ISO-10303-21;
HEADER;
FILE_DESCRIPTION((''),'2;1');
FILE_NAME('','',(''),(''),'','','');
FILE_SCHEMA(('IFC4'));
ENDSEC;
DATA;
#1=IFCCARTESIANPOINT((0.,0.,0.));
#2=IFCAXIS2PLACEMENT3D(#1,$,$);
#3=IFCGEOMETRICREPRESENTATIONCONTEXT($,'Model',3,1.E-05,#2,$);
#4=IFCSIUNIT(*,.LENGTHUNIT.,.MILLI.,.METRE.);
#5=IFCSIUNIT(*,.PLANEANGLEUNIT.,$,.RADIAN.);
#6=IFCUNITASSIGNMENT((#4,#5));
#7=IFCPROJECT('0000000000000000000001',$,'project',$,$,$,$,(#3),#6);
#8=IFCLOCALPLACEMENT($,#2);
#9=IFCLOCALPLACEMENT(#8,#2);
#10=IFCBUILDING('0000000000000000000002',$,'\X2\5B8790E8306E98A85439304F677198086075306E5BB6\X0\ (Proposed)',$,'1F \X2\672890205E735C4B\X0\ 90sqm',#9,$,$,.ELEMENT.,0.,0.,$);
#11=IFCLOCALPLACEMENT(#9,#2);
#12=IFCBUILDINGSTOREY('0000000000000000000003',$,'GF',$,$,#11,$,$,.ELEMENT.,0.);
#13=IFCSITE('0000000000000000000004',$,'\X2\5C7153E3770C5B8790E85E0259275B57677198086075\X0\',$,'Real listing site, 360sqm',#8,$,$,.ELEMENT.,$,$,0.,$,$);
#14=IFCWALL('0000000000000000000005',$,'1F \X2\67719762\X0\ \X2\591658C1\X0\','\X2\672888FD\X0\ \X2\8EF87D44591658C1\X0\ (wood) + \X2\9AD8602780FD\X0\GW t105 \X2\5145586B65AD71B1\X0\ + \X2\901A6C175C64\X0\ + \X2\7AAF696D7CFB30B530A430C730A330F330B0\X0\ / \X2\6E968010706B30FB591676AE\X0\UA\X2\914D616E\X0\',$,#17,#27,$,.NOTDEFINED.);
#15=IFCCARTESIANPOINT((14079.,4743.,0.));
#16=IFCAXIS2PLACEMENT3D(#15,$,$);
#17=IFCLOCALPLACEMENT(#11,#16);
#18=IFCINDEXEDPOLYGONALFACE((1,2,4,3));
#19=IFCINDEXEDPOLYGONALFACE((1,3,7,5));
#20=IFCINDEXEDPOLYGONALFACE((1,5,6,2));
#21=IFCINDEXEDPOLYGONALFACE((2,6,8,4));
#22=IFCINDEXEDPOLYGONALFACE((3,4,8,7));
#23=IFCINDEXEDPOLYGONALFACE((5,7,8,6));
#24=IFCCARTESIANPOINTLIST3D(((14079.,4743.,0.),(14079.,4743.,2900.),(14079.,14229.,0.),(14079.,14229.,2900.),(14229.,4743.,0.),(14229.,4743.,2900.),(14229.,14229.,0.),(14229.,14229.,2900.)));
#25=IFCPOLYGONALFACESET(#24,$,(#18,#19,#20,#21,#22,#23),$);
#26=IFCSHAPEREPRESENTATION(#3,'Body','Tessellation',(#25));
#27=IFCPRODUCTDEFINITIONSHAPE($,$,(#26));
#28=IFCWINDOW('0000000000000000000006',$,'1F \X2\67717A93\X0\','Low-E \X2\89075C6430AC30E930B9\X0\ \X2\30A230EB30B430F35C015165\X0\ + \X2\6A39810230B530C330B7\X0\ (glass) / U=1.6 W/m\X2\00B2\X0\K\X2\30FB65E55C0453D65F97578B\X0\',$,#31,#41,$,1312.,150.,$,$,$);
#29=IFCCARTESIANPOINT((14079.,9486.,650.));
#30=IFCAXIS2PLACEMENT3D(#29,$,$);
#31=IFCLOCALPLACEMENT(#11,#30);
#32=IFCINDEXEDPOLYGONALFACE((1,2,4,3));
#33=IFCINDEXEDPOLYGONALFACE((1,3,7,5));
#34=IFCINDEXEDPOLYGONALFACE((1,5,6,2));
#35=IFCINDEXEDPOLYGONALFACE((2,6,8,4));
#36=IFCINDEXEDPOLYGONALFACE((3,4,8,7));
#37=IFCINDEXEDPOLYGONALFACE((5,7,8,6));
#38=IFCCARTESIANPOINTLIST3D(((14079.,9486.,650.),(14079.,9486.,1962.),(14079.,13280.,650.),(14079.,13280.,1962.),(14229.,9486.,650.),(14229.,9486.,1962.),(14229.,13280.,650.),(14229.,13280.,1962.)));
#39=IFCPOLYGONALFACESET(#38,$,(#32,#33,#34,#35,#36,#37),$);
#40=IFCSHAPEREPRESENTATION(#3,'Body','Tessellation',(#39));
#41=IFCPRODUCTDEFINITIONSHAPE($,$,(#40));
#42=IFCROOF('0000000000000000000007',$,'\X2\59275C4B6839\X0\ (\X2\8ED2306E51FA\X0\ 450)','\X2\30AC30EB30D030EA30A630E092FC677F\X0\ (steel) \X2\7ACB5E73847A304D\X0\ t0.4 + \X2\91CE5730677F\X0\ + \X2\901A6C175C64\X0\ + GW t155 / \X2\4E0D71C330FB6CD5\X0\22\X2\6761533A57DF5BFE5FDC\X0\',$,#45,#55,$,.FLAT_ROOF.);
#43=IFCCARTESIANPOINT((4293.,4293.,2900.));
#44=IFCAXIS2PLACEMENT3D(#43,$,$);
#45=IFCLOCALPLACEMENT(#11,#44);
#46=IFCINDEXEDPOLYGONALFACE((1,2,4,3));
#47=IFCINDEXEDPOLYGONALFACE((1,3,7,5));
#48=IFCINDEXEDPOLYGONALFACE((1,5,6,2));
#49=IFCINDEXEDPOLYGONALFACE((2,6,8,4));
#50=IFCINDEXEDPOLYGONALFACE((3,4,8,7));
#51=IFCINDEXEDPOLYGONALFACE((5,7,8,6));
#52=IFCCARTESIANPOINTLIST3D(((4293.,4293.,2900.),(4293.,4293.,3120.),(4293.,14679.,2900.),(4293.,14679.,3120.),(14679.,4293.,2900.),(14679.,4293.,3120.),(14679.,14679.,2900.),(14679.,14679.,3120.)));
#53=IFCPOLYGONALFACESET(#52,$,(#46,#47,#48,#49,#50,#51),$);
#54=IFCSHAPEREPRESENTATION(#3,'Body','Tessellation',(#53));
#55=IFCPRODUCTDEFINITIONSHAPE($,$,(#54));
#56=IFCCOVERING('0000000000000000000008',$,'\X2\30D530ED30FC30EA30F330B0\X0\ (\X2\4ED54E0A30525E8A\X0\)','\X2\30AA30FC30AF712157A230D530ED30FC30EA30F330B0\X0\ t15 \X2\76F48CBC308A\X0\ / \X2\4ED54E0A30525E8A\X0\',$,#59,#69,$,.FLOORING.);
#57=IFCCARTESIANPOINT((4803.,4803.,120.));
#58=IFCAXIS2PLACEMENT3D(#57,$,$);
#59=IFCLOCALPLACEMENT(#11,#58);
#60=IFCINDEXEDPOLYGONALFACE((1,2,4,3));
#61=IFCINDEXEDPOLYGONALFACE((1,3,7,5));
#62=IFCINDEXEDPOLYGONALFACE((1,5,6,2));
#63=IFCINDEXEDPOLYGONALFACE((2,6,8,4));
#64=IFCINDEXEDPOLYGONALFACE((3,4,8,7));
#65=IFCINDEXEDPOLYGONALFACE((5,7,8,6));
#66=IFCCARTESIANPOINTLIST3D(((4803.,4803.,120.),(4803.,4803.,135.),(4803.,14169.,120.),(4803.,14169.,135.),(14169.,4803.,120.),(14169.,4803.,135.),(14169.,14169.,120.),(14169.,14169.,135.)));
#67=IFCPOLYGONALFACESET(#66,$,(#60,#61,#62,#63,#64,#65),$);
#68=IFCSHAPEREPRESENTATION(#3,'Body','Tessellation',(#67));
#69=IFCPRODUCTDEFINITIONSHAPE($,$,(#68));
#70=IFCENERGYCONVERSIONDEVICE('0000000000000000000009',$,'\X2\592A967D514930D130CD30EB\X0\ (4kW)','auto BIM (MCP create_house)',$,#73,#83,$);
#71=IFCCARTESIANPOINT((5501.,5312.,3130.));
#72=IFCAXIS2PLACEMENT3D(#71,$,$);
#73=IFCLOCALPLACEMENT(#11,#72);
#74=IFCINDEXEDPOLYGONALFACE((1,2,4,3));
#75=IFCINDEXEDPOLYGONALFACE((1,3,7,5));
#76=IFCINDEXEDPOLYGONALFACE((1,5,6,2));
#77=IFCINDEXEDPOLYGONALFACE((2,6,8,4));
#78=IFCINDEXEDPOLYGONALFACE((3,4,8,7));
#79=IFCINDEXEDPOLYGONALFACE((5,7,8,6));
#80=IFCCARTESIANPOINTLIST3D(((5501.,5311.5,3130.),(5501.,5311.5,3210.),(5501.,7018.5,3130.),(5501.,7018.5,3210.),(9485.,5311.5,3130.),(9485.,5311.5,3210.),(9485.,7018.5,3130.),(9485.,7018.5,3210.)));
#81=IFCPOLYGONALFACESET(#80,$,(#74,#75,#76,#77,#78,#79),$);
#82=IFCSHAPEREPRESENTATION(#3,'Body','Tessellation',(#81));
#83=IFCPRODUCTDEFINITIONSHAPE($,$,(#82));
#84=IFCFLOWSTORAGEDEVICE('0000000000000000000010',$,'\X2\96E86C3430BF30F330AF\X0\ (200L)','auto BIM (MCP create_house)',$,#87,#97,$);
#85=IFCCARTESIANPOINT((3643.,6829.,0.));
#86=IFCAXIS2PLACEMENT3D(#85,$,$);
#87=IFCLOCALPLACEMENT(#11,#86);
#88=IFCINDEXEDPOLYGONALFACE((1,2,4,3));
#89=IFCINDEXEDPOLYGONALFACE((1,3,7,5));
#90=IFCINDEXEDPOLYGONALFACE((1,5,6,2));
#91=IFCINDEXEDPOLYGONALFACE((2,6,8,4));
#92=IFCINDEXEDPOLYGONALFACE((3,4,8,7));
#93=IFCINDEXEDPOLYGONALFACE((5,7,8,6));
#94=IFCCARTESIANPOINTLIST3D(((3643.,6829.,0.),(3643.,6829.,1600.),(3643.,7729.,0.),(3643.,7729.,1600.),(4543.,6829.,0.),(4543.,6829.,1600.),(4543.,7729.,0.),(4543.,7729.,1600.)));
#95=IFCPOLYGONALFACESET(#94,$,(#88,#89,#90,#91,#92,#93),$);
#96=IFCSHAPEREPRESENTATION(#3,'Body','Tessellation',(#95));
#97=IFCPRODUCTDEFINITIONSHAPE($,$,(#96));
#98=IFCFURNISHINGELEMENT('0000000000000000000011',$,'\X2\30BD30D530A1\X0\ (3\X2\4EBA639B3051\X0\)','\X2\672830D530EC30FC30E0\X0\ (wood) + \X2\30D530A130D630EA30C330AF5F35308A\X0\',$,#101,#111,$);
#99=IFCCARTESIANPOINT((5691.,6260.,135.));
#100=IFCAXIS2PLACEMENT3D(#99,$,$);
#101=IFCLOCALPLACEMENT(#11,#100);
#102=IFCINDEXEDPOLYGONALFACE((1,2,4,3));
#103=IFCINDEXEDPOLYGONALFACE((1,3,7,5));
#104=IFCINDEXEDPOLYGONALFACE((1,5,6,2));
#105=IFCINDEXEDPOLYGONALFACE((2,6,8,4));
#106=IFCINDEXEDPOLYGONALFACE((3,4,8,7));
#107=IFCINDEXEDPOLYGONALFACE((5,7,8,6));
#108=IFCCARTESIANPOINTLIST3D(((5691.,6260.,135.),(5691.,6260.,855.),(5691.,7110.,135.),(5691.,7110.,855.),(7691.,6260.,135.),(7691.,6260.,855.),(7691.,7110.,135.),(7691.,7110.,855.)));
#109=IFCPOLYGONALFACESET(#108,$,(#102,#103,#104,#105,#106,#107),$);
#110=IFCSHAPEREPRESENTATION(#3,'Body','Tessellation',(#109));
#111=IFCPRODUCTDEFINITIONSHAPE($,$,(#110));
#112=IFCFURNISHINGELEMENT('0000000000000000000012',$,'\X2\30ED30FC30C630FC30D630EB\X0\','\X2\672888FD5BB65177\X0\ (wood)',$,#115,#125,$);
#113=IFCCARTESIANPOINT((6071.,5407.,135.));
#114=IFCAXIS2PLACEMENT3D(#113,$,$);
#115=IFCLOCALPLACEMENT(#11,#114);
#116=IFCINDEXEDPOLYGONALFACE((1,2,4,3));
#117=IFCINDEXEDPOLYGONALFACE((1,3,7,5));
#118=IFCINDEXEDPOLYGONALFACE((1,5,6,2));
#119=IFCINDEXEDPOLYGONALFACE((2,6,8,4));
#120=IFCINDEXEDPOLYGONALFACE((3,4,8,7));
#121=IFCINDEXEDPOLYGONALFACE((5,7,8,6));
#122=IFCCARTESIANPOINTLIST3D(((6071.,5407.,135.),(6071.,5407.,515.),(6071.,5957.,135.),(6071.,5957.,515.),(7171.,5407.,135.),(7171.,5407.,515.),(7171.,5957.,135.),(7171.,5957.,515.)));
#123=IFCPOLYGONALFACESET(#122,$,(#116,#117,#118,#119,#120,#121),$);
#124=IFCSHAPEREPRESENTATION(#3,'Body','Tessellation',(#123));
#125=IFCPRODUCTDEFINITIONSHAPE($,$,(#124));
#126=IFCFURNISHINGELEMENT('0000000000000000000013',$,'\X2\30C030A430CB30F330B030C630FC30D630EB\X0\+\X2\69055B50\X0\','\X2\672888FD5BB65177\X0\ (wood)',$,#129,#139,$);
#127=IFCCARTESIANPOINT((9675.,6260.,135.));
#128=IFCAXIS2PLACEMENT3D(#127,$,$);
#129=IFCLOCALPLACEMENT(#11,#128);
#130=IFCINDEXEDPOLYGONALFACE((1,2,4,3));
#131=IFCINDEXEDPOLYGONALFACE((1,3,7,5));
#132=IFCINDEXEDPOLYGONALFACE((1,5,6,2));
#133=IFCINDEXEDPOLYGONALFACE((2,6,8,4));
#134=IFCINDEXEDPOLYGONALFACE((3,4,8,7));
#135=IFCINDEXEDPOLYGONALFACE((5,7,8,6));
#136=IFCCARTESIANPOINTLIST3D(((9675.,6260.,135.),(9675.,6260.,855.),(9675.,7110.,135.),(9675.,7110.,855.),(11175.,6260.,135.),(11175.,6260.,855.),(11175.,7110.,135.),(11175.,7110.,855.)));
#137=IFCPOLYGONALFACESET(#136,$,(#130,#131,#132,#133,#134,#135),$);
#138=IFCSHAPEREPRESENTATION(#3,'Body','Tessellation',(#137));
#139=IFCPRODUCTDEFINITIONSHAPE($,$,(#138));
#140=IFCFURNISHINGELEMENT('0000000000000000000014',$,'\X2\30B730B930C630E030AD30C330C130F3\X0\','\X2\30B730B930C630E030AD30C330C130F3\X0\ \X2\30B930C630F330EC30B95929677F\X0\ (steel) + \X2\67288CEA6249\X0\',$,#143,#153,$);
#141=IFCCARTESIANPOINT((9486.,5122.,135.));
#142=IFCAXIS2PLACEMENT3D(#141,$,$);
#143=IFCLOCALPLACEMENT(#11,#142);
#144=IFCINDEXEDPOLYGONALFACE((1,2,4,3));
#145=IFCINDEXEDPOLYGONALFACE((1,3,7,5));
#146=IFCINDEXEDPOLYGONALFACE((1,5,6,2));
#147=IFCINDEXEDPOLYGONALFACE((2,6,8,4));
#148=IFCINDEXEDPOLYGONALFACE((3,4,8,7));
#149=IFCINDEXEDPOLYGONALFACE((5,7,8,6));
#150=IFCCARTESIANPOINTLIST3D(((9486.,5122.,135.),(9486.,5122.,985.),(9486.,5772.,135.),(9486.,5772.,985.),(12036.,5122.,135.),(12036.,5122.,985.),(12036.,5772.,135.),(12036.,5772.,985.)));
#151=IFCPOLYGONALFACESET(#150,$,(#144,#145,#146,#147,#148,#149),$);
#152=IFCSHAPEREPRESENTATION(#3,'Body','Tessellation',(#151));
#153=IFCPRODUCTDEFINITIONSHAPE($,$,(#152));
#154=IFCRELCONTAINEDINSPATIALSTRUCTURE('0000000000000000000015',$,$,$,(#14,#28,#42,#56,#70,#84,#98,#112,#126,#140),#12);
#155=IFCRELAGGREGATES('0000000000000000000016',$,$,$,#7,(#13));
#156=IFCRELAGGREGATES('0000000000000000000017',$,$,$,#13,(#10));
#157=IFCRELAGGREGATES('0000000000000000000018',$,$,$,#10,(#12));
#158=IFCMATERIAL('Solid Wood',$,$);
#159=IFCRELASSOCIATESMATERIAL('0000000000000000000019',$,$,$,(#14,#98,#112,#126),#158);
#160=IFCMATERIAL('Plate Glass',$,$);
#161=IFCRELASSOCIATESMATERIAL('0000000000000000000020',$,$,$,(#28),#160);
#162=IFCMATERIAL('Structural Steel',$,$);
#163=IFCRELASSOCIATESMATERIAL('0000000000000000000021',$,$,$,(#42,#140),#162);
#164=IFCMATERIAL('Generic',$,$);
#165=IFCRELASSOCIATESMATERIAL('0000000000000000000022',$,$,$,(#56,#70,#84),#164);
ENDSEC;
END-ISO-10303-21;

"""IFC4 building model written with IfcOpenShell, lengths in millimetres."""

from ifc_helpers import new_model, si_unit, frame, frame_2d, origin, place, context, project, spatial, rectangle, extrude, material, element, fill, save


model = new_model("IFC4")

# Units and contexts
model_context = context("Model", 3, precision=1e-05, world=origin())
ifc_project = project(units=[si_unit("LENGTHUNIT", "METRE", prefix="MILLI"), si_unit("PLANEANGLEUNIT", "RADIAN")], contexts=[model_context])

# Site, building, storey
site_placement = place(None, origin())
site = spatial("IfcSite", under=ifc_project, at=site_placement, Name="山口県宇部市大字東須恵", ObjectType="Real listing site, 360sqm", CompositionType="ELEMENT", RefElevation=0.0)
building_placement = place(site_placement, origin())
building = spatial("IfcBuilding", under=site, at=building_placement, Name="宇部の風吹く東須恵の家 (Proposed)", ObjectType="1F 木造平屋 90sqm", CompositionType="ELEMENT", ElevationOfRefHeight=0.0, ElevationOfTerrain=0.0)
storey_placement = place(building_placement, origin())
storey = spatial("IfcBuildingStorey", under=building, at=storey_placement, Name="GF", CompositionType="ELEMENT", Elevation=0.0)

# Shared definitions
ifc_material_1 = material(Name="Solid Wood")

# Shared definitions
ifc_material_2 = material(Name="Plate Glass")

# Wall, opening, window
wall_1_placement = place(storey_placement, frame((14079.0, 4743.0, 0.0)))
wall_1 = element("IfcWall", 1, at=wall_1_placement, inside=storey, material=ifc_material_1, Name="1F 東面 外壁", Description="木製 軸組外壁 (wood) + 高性能GW t105 充填断熱 + 通気層 + 窯業系サイディング / 準耐火・外皮UA配慮", PredefinedType="NOTDEFINED", context=model_context, shape_type="SweptSolid", body=[
    extrude(rectangle(XDim=150.0, YDim=9486.0, at=frame_2d((75.0, 4743.0))), frame((14079.0, 4743.0, 0.0)), (0.0, 0.0, 1.0), 2900.0),
])
opening_1_placement = place(storey_placement, frame((14079.0, 9486.0, 650.0)))
opening_1 = element("IfcOpeningElement", 2, at=opening_1_placement, cuts=wall_1, PredefinedType="NOTDEFINED", context=model_context, shape_type="SweptSolid", body=[
    extrude(rectangle(XDim=150.0, YDim=3794.0, at=frame_2d((75.0, 1897.0))), frame((14079.0, 9486.0, 650.0)), (0.0, 0.0, 1.0), 1312.0),
])
window_1_placement = place(storey_placement, frame((14079.0, 9486.0, 650.0)))
window_1 = element("IfcWindow", 3, at=window_1_placement, inside=storey, material=ifc_material_2, Name="1F 東窓", Description="Low-E 複層ガラス アルゴン封入 + 樹脂サッシ (glass) / U=1.6 W/m²K・日射取得型", OverallHeight=1312.0, OverallWidth=150.0, context=model_context, shape_type="SweptSolid", body=[
    extrude(rectangle(XDim=150.0, YDim=3794.0, at=frame_2d((75.0, 1897.0))), frame((14079.0, 9486.0, 650.0)), (0.0, 0.0, 1.0), 1312.0),
])
fill(opening_1, window_1)

# Roof
ifc_material_3 = material(Name="Structural Steel")
roof_placement = place(storey_placement, frame((4293.0, 4293.0, 2900.0)))
element("IfcRoof", 4, at=roof_placement, inside=storey, material=ifc_material_3, Name="大屋根 (軒の出 450)", Description="ガルバリウム鋼板 (steel) 立平葺き t0.4 + 野地板 + 通気層 + GW t155 / 不燃・法22条区域対応", PredefinedType="FLAT_ROOF", context=model_context, shape_type="SweptSolid", body=[
    extrude(rectangle(XDim=10386.0, YDim=10386.0, at=frame_2d((5193.0, 5193.0))), frame((4293.0, 4293.0, 2900.0)), (0.0, 0.0, 1.0), 220.0),
])

# Covering
ifc_material_4 = material(Name="Generic")
covering_placement = place(storey_placement, frame((4803.0, 4803.0, 120.0)))
element("IfcCovering", 5, at=covering_placement, inside=storey, material=ifc_material_4, Name="フローリング (仕上げ床)", Description="オーク無垢フローリング t15 直貼り / 仕上げ床", PredefinedType="FLOORING", context=model_context, shape_type="SweptSolid", body=[
    extrude(rectangle(XDim=9366.0, YDim=9366.0, at=frame_2d((4683.0, 4683.0))), frame((4803.0, 4803.0, 120.0)), (0.0, 0.0, 1.0), 15.0),
])

# Energy conversion device
energy_conversion_device_placement = place(storey_placement, frame((5501.0, 5312.0, 3130.0)))
element("IfcEnergyConversionDevice", 6, at=energy_conversion_device_placement, inside=storey, material=ifc_material_4, Name="太陽光パネル (4kW)", Description="auto BIM (MCP create_house)", context=model_context, shape_type="SweptSolid", body=[
    extrude(rectangle(XDim=3984.0, YDim=1707.0, at=frame_2d((1992.0, 853.0))), frame((5501.0, 5312.0, 3130.0)), (0.0, 0.0, 1.0), 80.0),
])

# Flow storage device
flow_storage_device_placement = place(storey_placement, frame((3643.0, 6829.0, 0.0)))
element("IfcFlowStorageDevice", 7, at=flow_storage_device_placement, inside=storey, material=ifc_material_4, Name="雨水タンク (200L)", Description="auto BIM (MCP create_house)", context=model_context, shape_type="SweptSolid", body=[
    extrude(rectangle(XDim=900.0, YDim=900.0, at=frame_2d((450.0, 450.0))), frame((3643.0, 6829.0, 0.0)), (0.0, 0.0, 1.0), 1600.0),
])

# Furnishing elements
furnishing_1_placement = place(storey_placement, frame((5691.0, 6260.0, 135.0)))
element("IfcFurnishingElement", 8, at=furnishing_1_placement, inside=storey, material=ifc_material_1, Name="ソファ (3人掛け)", Description="木フレーム (wood) + ファブリック張り", context=model_context, shape_type="SweptSolid", body=[
    extrude(rectangle(XDim=2000.0, YDim=850.0, at=frame_2d((1000.0, 425.0))), frame((5691.0, 6260.0, 135.0)), (0.0, 0.0, 1.0), 720.0),
])
furnishing_2_placement = place(storey_placement, frame((6071.0, 5407.0, 135.0)))
element("IfcFurnishingElement", 9, at=furnishing_2_placement, inside=storey, material=ifc_material_1, Name="ローテーブル", Description="木製家具 (wood)", context=model_context, shape_type="SweptSolid", body=[
    extrude(rectangle(XDim=1100.0, YDim=550.0, at=frame_2d((550.0, 275.0))), frame((6071.0, 5407.0, 135.0)), (0.0, 0.0, 1.0), 380.0),
])
furnishing_3_placement = place(storey_placement, frame((9675.0, 6260.0, 135.0)))
element("IfcFurnishingElement", 10, at=furnishing_3_placement, inside=storey, material=ifc_material_1, Name="ダイニングテーブル+椅子", Description="木製家具 (wood)", context=model_context, shape_type="SweptSolid", body=[
    extrude(rectangle(XDim=1500.0, YDim=850.0, at=frame_2d((750.0, 425.0))), frame((9675.0, 6260.0, 135.0)), (0.0, 0.0, 1.0), 720.0),
])
furnishing_4_placement = place(storey_placement, frame((9486.0, 5122.0, 135.0)))
element("IfcFurnishingElement", 11, at=furnishing_4_placement, inside=storey, material=ifc_material_3, Name="システムキッチン", Description="システムキッチン ステンレス天板 (steel) + 木質扉", context=model_context, shape_type="SweptSolid", body=[
    extrude(rectangle(XDim=2550.0, YDim=650.0, at=frame_2d((1275.0, 325.0))), frame((9486.0, 5122.0, 135.0)), (0.0, 0.0, 1.0), 850.0),
])

save(model, "model.ifc")
